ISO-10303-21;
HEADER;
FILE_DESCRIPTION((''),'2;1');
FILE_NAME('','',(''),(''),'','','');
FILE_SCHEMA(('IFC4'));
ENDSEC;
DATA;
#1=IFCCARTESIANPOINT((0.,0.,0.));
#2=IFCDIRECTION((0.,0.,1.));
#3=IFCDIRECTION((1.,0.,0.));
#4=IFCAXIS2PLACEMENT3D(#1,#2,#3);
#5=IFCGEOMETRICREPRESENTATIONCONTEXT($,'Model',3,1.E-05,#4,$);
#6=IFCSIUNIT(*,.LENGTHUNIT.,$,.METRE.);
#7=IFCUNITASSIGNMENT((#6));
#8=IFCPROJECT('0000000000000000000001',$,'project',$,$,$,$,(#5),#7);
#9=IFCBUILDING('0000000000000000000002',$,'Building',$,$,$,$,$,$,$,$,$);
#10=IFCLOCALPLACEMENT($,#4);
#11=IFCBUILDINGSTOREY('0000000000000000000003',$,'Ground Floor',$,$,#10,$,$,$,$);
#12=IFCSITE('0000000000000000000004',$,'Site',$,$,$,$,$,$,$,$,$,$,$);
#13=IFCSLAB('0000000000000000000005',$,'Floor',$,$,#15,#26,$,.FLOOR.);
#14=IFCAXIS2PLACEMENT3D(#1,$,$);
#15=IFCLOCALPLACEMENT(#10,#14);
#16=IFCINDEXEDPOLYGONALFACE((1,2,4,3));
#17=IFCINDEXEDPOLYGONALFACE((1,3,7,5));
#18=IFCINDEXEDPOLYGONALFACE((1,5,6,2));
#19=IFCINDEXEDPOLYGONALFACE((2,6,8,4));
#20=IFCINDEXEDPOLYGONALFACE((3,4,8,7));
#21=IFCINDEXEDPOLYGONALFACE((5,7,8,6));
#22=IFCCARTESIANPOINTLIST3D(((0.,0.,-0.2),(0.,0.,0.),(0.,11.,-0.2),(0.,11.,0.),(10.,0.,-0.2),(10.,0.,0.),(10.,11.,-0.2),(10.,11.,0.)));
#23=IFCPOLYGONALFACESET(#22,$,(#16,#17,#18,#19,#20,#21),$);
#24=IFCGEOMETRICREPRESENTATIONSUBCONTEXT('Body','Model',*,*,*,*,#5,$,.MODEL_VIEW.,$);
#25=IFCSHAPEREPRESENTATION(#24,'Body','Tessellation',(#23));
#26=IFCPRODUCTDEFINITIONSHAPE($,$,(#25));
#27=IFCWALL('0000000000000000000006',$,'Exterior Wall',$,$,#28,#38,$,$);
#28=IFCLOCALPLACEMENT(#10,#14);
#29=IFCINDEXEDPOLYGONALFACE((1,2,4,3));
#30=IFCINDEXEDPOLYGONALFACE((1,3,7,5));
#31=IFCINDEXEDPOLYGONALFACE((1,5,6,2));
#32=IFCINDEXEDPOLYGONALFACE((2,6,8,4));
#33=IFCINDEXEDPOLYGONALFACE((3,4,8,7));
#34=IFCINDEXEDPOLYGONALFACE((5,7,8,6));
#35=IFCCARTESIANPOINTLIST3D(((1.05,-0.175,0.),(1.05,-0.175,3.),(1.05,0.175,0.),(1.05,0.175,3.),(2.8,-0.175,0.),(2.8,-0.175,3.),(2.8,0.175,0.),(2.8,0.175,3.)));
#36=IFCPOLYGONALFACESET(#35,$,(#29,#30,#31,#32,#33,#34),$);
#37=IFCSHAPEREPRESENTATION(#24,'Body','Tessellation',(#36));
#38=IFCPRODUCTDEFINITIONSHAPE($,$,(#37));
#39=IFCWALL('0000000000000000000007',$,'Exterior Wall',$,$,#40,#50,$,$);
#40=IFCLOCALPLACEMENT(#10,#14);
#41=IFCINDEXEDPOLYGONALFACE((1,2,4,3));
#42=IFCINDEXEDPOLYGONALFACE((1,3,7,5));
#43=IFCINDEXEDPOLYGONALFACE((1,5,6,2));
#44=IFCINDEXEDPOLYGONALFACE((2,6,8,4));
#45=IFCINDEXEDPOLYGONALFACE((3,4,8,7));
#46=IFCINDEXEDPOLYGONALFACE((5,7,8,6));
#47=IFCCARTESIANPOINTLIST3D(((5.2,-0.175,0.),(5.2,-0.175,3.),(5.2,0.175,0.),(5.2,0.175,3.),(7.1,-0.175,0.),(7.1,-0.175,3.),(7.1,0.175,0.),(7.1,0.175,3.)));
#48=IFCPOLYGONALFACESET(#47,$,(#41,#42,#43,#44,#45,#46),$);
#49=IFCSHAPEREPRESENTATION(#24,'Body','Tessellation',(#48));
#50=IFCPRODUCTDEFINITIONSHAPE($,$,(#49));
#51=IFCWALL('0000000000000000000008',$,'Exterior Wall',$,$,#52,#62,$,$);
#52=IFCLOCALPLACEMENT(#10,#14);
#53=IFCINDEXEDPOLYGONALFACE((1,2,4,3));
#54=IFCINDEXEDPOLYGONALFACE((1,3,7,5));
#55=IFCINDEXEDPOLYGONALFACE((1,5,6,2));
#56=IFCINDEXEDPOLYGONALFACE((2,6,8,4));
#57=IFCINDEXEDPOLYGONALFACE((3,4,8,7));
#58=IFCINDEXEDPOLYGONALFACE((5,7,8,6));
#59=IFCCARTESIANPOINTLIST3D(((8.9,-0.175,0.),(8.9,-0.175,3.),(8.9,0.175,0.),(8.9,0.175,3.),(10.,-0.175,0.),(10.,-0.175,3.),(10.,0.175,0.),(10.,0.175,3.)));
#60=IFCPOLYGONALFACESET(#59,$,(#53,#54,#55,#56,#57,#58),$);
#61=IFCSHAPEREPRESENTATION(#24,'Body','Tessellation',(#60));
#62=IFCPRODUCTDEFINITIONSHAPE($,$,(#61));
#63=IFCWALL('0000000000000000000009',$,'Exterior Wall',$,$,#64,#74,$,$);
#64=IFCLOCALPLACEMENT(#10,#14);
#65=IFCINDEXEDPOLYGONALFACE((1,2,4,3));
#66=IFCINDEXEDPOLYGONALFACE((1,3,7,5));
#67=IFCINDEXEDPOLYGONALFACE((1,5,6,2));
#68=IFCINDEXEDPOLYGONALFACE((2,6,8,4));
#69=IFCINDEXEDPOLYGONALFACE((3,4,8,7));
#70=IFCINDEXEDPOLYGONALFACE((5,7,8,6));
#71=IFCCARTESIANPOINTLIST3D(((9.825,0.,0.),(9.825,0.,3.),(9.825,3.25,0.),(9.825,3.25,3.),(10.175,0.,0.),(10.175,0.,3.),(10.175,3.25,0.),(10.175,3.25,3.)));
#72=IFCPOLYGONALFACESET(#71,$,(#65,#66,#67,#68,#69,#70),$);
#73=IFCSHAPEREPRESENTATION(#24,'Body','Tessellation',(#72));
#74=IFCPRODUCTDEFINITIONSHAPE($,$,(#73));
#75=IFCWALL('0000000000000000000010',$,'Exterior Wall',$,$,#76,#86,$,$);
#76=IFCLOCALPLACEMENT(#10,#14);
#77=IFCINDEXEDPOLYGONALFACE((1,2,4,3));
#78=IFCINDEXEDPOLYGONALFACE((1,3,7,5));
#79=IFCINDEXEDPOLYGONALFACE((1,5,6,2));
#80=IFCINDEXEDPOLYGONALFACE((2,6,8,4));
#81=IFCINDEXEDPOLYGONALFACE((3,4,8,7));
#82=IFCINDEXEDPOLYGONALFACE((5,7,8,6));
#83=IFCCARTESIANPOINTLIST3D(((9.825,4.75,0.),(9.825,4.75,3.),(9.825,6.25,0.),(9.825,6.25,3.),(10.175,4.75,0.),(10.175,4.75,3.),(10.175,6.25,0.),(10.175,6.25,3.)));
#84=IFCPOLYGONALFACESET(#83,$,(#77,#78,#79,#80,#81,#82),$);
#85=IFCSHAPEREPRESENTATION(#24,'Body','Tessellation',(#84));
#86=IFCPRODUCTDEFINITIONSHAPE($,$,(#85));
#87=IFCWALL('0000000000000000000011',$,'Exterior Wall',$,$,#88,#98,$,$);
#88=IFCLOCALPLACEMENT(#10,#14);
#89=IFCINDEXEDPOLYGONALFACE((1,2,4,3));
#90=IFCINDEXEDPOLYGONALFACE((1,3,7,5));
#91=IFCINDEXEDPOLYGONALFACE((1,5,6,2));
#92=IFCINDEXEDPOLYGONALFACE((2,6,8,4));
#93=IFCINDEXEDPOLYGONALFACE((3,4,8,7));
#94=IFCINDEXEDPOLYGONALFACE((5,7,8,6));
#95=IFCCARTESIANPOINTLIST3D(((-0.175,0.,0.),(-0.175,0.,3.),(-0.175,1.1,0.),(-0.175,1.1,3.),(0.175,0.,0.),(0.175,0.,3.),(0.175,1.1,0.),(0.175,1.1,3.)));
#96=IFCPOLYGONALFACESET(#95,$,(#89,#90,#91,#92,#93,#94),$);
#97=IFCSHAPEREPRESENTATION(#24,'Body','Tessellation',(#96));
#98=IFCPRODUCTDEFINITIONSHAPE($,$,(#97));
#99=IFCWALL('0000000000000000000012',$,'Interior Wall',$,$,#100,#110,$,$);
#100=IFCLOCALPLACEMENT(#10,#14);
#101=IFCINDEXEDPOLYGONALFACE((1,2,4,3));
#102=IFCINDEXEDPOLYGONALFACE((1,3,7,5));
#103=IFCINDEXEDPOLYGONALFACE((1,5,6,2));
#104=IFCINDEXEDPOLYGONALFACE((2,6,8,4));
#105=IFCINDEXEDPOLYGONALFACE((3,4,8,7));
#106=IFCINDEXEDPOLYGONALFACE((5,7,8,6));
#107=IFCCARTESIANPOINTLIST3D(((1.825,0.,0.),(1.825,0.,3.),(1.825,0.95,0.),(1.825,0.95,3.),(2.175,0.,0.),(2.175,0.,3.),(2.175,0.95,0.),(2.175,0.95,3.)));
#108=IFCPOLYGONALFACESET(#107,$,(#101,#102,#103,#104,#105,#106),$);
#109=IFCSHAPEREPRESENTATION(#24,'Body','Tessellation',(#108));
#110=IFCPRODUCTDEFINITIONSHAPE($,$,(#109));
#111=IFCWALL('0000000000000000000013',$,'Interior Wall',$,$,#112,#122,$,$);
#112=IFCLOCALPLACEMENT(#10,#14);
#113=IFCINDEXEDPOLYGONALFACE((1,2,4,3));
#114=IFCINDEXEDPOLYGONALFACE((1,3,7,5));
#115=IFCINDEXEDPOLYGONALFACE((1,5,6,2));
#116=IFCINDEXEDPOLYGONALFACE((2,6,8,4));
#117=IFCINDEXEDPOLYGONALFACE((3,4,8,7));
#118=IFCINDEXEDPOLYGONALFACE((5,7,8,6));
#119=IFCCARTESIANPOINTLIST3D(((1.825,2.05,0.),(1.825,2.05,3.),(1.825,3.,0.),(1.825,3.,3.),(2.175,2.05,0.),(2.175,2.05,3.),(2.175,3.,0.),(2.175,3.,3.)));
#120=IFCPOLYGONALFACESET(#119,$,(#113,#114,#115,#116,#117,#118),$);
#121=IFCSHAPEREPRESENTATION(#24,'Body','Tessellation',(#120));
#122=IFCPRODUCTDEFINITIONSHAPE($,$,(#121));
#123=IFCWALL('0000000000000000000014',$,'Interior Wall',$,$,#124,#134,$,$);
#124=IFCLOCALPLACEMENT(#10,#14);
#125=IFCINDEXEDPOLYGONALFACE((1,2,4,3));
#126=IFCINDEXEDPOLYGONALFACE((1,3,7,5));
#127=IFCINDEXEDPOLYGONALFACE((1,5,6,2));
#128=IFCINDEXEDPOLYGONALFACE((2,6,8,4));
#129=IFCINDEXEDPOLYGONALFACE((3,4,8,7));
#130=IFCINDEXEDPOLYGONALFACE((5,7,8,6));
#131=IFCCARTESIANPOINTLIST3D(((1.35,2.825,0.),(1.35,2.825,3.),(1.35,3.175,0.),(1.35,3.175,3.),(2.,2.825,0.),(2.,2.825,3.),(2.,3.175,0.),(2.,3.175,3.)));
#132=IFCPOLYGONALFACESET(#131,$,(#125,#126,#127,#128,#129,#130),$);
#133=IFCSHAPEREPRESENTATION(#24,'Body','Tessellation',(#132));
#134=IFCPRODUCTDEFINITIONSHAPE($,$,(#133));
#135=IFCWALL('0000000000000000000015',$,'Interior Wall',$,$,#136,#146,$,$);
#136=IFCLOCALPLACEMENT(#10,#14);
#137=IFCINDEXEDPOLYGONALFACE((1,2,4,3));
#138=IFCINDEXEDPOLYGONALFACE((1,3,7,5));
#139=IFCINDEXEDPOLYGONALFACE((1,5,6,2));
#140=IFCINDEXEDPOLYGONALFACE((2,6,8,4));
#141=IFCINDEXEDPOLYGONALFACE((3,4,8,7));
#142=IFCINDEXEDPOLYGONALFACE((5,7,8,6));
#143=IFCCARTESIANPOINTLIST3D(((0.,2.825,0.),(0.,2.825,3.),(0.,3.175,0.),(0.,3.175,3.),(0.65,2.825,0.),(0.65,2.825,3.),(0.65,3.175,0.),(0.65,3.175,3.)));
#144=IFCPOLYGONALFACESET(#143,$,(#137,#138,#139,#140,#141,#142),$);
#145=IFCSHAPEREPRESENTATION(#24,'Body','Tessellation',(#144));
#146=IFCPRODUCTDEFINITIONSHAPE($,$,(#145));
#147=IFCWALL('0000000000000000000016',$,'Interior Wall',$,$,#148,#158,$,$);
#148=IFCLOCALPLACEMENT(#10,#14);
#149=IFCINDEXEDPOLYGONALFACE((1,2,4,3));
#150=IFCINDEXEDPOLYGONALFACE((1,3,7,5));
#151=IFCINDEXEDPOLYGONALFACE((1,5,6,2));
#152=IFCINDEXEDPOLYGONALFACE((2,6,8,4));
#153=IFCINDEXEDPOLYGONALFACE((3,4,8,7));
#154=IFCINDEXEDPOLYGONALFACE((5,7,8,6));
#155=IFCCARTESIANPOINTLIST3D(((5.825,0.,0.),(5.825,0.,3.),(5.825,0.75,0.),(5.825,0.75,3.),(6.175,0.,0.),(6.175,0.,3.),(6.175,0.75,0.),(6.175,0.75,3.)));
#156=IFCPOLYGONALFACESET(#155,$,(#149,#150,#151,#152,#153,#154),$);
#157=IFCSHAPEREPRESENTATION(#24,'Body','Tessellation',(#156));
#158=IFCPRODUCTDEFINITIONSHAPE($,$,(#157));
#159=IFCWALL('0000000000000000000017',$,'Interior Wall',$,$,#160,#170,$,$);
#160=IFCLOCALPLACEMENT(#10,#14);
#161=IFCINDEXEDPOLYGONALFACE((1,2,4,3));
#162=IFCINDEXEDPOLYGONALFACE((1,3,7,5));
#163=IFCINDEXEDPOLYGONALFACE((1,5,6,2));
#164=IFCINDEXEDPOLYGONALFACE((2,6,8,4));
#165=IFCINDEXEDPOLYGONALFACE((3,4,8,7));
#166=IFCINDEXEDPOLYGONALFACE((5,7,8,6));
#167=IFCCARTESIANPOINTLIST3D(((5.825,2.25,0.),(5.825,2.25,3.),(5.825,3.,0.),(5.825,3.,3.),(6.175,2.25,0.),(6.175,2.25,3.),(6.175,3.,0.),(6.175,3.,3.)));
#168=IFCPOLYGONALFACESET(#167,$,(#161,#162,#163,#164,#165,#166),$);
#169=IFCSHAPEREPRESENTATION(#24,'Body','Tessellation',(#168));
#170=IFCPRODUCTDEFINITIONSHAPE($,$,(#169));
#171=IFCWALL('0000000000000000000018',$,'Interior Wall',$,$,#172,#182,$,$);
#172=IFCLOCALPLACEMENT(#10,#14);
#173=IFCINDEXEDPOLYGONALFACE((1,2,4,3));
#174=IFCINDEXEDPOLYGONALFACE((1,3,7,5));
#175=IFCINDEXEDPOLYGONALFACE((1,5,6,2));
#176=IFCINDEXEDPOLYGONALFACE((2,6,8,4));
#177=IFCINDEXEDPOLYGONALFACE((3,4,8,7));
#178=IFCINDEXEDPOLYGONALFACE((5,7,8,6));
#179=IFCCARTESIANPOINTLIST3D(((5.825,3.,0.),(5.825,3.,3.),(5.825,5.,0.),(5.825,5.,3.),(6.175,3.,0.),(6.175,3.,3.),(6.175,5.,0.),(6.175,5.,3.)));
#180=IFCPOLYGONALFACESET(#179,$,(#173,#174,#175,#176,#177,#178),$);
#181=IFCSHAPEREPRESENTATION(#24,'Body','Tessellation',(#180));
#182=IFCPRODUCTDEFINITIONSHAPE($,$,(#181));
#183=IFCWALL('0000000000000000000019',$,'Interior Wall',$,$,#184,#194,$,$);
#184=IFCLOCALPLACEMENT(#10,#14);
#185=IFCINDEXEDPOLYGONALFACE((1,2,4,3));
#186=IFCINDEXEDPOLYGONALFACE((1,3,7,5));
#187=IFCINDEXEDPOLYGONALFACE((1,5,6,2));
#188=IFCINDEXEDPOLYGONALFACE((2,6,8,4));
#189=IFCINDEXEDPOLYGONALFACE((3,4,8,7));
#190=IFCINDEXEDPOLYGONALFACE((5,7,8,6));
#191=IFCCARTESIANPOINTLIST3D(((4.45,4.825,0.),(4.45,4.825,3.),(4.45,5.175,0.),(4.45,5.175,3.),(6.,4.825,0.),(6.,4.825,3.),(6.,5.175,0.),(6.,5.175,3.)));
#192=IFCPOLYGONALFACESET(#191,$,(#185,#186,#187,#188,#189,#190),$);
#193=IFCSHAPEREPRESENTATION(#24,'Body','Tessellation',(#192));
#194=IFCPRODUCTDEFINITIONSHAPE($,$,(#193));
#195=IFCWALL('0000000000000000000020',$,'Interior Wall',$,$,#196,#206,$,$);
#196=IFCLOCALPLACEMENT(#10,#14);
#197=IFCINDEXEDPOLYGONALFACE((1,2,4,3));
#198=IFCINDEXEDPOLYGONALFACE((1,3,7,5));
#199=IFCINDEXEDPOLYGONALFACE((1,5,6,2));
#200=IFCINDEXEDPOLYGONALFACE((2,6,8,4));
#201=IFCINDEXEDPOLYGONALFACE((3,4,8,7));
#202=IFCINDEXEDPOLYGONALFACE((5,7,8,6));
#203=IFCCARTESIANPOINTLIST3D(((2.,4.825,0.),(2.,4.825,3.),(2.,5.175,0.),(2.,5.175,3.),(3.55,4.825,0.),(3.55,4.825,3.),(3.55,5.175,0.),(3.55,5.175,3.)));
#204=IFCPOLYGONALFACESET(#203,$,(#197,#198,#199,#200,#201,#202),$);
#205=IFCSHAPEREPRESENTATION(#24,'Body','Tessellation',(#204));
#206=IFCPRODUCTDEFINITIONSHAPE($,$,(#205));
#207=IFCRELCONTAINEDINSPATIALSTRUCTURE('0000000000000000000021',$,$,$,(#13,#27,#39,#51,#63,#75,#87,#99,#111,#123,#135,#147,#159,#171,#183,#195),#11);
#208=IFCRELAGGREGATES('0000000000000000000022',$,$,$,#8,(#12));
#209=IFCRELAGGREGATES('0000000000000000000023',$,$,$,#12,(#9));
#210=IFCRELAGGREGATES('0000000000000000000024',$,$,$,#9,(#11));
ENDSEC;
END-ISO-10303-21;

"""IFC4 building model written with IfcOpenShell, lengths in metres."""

from ifc_helpers import new_model, si_unit, frame, origin_with_axes, place, context, subcontext, project, spatial, indexed_curve, outline, extrude, element, save


model = new_model("IFC4")

# Units and contexts
model_context = context("Model", 3, precision=1e-05, world=origin_with_axes())
body_context = subcontext(model_context, "Body", "Model", "MODEL_VIEW")
ifc_project = project(units=[si_unit("LENGTHUNIT", "METRE")], contexts=[model_context])

# Site, building, storey
site = spatial("IfcSite", under=ifc_project, Name="Site")
building = spatial("IfcBuilding", under=site, Name="Building")
storey_placement = place(None, origin_with_axes())
storey = spatial("IfcBuildingStorey", under=building, at=storey_placement, Name="Ground Floor")

# Slab
slab_placement = place(storey_placement, frame((0.0, 0.0, -0.2), z_axis=(0.0, 0.0, 1.0), x_axis=(1.0, 0.0, 0.0)))
element("IfcSlab", 1, at=slab_placement, inside=storey, Name="Floor", PredefinedType="FLOOR", context=body_context, shape_type="SweptSolid", body=[
    extrude(outline(indexed_curve([(0.0, 0.0), (10.0, 0.0), (10.0, 11.0), (0.0, 11.0)])), None, (0.0, 0.0, 1.0), 0.2),
])

# Walls
wall_1_placement = place(storey_placement, frame((1.05, 0.0, 0.0), z_axis=(0.0, 0.0, 1.0), x_axis=(1.0, 0.0, 0.0)))
element("IfcWall", 2, at=wall_1_placement, inside=storey, Name="Exterior Wall", context=body_context, shape_type="SweptSolid", body=[
    extrude(outline(indexed_curve([(0.0, 0.0), (0.0, 0.35), (1.75, 0.35), (1.75, 0.0), (0.0, 0.0)], self_intersect=False)), frame((0.0, -0.175, 0.0), z_axis=(0.0, 0.0, 1.0), x_axis=(1.0, 0.0, 0.0)), (0.0, 0.0, 1.0), 3.0),
])
wall_2_placement = place(storey_placement, frame((5.2, 0.0, 0.0), z_axis=(0.0, 0.0, 1.0), x_axis=(1.0, 0.0, 0.0)))
element("IfcWall", 3, at=wall_2_placement, inside=storey, Name="Exterior Wall", context=body_context, shape_type="SweptSolid", body=[
    extrude(outline(indexed_curve([(0.0, 0.0), (0.0, 0.35), (1.9, 0.35), (1.9, 0.0), (0.0, 0.0)], self_intersect=False)), frame((0.0, -0.175, 0.0), z_axis=(0.0, 0.0, 1.0), x_axis=(1.0, 0.0, 0.0)), (0.0, 0.0, 1.0), 3.0),
])
wall_3_placement = place(storey_placement, frame((8.9, 0.0, 0.0), z_axis=(0.0, 0.0, 1.0), x_axis=(1.0, 0.0, 0.0)))
element("IfcWall", 4, at=wall_3_placement, inside=storey, Name="Exterior Wall", context=body_context, shape_type="SweptSolid", body=[
    extrude(outline(indexed_curve([(0.0, 0.0), (0.0, 0.35), (1.1, 0.35), (1.1, 0.0), (0.0, 0.0)], self_intersect=False)), frame((0.0, -0.175, 0.0), z_axis=(0.0, 0.0, 1.0), x_axis=(1.0, 0.0, 0.0)), (0.0, 0.0, 1.0), 3.0),
])
wall_4_placement = place(storey_placement, frame((10.0, 0.0, 0.0), z_axis=(0.0, 0.0, 1.0), x_axis=(0.0, 1.0, 0.0)))
element("IfcWall", 5, at=wall_4_placement, inside=storey, Name="Exterior Wall", context=body_context, shape_type="SweptSolid", body=[
    extrude(outline(indexed_curve([(0.0, 0.0), (0.0, 0.35), (3.25, 0.35), (3.25, 0.0), (0.0, 0.0)], self_intersect=False)), frame((0.0, -0.175, 0.0), z_axis=(0.0, 0.0, 1.0), x_axis=(1.0, 0.0, 0.0)), (0.0, 0.0, 1.0), 3.0),
])
wall_5_placement = place(storey_placement, frame((10.0, 4.75, 0.0), z_axis=(0.0, 0.0, 1.0), x_axis=(0.0, 1.0, 0.0)))
element("IfcWall", 6, at=wall_5_placement, inside=storey, Name="Exterior Wall", context=body_context, shape_type="SweptSolid", body=[
    extrude(outline(indexed_curve([(0.0, 0.0), (0.0, 0.35), (1.5, 0.35), (1.5, 0.0), (0.0, 0.0)], self_intersect=False)), frame((0.0, -0.175, 0.0), z_axis=(0.0, 0.0, 1.0), x_axis=(1.0, 0.0, 0.0)), (0.0, 0.0, 1.0), 3.0),
])
wall_6_placement = place(storey_placement, frame((0.0, 1.1, 0.0), z_axis=(0.0, 0.0, 1.0), x_axis=(0.0, -1.0, 0.0)))
element("IfcWall", 7, at=wall_6_placement, inside=storey, Name="Exterior Wall", context=body_context, shape_type="SweptSolid", body=[
    extrude(outline(indexed_curve([(0.0, 0.0), (0.0, 0.35), (1.1, 0.35), (1.1, 0.0), (0.0, 0.0)], self_intersect=False)), frame((0.0, -0.175, 0.0), z_axis=(0.0, 0.0, 1.0), x_axis=(1.0, 0.0, 0.0)), (0.0, 0.0, 1.0), 3.0),
])
wall_7_placement = place(storey_placement, frame((2.0, 0.0, 0.0), z_axis=(0.0, 0.0, 1.0), x_axis=(0.0, 1.0, 0.0)))
element("IfcWall", 8, at=wall_7_placement, inside=storey, Name="Interior Wall", context=body_context, shape_type="SweptSolid", body=[
    extrude(outline(indexed_curve([(0.0, 0.0), (0.0, 0.35), (0.95, 0.35), (0.95, 0.0), (0.0, 0.0)], self_intersect=False)), frame((0.0, -0.175, 0.0), z_axis=(0.0, 0.0, 1.0), x_axis=(1.0, 0.0, 0.0)), (0.0, 0.0, 1.0), 3.0),
])
wall_8_placement = place(storey_placement, frame((2.0, 2.05, 0.0), z_axis=(0.0, 0.0, 1.0), x_axis=(0.0, 1.0, 0.0)))
element("IfcWall", 9, at=wall_8_placement, inside=storey, Name="Interior Wall", context=body_context, shape_type="SweptSolid", body=[
    extrude(outline(indexed_curve([(0.0, 0.0), (0.0, 0.35), (0.95, 0.35), (0.95, 0.0), (0.0, 0.0)], self_intersect=False)), frame((0.0, -0.175, 0.0), z_axis=(0.0, 0.0, 1.0), x_axis=(1.0, 0.0, 0.0)), (0.0, 0.0, 1.0), 3.0),
])
for number, where, z_axis, x_axis, name in (
    (10, (2.0, 3.0, 0.0), (0.0, 0.0, 1.0), (-1.0, 0.0, 0.0), "Interior Wall"),
    (11, (0.65, 3.0, 0.0), (0.0, 0.0, 1.0), (-1.0, 0.0, 0.0), "Interior Wall"),
):
    element("IfcWall", number, at=place(storey_placement, frame(where, z_axis=z_axis, x_axis=x_axis)), inside=storey, Name=name, context=body_context, shape_type="SweptSolid", body=[
        extrude(outline(indexed_curve([(0.0, 0.0), (0.0, 0.35), (0.65, 0.35), (0.65, 0.0), (0.0, 0.0)], self_intersect=False)), frame((0.0, -0.175, 0.0), z_axis=(0.0, 0.0, 1.0), x_axis=(1.0, 0.0, 0.0)), (0.0, 0.0, 1.0), 3.0),
    ])
for number, where, z_axis, x_axis, name in (
    (12, (6.0, 0.0, 0.0), (0.0, 0.0, 1.0), (0.0, 1.0, 0.0), "Interior Wall"),
    (13, (6.0, 2.25, 0.0), (0.0, 0.0, 1.0), (0.0, 1.0, 0.0), "Interior Wall"),
):
    element("IfcWall", number, at=place(storey_placement, frame(where, z_axis=z_axis, x_axis=x_axis)), inside=storey, Name=name, context=body_context, shape_type="SweptSolid", body=[
        extrude(outline(indexed_curve([(0.0, 0.0), (0.0, 0.35), (0.75, 0.35), (0.75, 0.0), (0.0, 0.0)], self_intersect=False)), frame((0.0, -0.175, 0.0), z_axis=(0.0, 0.0, 1.0), x_axis=(1.0, 0.0, 0.0)), (0.0, 0.0, 1.0), 3.0),
    ])
wall_9_placement = place(storey_placement, frame((6.0, 3.0, 0.0), z_axis=(0.0, 0.0, 1.0), x_axis=(0.0, 1.0, 0.0)))
element("IfcWall", 14, at=wall_9_placement, inside=storey, Name="Interior Wall", context=body_context, shape_type="SweptSolid", body=[
    extrude(outline(indexed_curve([(0.0, 0.0), (0.0, 0.35), (2.0, 0.35), (2.0, 0.0), (0.0, 0.0)], self_intersect=False)), frame((0.0, -0.175, 0.0), z_axis=(0.0, 0.0, 1.0), x_axis=(1.0, 0.0, 0.0)), (0.0, 0.0, 1.0), 3.0),
])
for number, where, z_axis, x_axis, name in (
    (15, (6.0, 5.0, 0.0), (0.0, 0.0, 1.0), (-1.0, 0.0, 0.0), "Interior Wall"),
    (16, (3.55, 5.0, 0.0), (0.0, 0.0, 1.0), (-1.0, 0.0, 0.0), "Interior Wall"),
):
    element("IfcWall", number, at=place(storey_placement, frame(where, z_axis=z_axis, x_axis=x_axis)), inside=storey, Name=name, context=body_context, shape_type="SweptSolid", body=[
        extrude(outline(indexed_curve([(0.0, 0.0), (0.0, 0.35), (1.55, 0.35), (1.55, 0.0), (0.0, 0.0)], self_intersect=False)), frame((0.0, -0.175, 0.0), z_axis=(0.0, 0.0, 1.0), x_axis=(1.0, 0.0, 0.0)), (0.0, 0.0, 1.0), 3.0),
    ])

save(model, "model.ifc")
